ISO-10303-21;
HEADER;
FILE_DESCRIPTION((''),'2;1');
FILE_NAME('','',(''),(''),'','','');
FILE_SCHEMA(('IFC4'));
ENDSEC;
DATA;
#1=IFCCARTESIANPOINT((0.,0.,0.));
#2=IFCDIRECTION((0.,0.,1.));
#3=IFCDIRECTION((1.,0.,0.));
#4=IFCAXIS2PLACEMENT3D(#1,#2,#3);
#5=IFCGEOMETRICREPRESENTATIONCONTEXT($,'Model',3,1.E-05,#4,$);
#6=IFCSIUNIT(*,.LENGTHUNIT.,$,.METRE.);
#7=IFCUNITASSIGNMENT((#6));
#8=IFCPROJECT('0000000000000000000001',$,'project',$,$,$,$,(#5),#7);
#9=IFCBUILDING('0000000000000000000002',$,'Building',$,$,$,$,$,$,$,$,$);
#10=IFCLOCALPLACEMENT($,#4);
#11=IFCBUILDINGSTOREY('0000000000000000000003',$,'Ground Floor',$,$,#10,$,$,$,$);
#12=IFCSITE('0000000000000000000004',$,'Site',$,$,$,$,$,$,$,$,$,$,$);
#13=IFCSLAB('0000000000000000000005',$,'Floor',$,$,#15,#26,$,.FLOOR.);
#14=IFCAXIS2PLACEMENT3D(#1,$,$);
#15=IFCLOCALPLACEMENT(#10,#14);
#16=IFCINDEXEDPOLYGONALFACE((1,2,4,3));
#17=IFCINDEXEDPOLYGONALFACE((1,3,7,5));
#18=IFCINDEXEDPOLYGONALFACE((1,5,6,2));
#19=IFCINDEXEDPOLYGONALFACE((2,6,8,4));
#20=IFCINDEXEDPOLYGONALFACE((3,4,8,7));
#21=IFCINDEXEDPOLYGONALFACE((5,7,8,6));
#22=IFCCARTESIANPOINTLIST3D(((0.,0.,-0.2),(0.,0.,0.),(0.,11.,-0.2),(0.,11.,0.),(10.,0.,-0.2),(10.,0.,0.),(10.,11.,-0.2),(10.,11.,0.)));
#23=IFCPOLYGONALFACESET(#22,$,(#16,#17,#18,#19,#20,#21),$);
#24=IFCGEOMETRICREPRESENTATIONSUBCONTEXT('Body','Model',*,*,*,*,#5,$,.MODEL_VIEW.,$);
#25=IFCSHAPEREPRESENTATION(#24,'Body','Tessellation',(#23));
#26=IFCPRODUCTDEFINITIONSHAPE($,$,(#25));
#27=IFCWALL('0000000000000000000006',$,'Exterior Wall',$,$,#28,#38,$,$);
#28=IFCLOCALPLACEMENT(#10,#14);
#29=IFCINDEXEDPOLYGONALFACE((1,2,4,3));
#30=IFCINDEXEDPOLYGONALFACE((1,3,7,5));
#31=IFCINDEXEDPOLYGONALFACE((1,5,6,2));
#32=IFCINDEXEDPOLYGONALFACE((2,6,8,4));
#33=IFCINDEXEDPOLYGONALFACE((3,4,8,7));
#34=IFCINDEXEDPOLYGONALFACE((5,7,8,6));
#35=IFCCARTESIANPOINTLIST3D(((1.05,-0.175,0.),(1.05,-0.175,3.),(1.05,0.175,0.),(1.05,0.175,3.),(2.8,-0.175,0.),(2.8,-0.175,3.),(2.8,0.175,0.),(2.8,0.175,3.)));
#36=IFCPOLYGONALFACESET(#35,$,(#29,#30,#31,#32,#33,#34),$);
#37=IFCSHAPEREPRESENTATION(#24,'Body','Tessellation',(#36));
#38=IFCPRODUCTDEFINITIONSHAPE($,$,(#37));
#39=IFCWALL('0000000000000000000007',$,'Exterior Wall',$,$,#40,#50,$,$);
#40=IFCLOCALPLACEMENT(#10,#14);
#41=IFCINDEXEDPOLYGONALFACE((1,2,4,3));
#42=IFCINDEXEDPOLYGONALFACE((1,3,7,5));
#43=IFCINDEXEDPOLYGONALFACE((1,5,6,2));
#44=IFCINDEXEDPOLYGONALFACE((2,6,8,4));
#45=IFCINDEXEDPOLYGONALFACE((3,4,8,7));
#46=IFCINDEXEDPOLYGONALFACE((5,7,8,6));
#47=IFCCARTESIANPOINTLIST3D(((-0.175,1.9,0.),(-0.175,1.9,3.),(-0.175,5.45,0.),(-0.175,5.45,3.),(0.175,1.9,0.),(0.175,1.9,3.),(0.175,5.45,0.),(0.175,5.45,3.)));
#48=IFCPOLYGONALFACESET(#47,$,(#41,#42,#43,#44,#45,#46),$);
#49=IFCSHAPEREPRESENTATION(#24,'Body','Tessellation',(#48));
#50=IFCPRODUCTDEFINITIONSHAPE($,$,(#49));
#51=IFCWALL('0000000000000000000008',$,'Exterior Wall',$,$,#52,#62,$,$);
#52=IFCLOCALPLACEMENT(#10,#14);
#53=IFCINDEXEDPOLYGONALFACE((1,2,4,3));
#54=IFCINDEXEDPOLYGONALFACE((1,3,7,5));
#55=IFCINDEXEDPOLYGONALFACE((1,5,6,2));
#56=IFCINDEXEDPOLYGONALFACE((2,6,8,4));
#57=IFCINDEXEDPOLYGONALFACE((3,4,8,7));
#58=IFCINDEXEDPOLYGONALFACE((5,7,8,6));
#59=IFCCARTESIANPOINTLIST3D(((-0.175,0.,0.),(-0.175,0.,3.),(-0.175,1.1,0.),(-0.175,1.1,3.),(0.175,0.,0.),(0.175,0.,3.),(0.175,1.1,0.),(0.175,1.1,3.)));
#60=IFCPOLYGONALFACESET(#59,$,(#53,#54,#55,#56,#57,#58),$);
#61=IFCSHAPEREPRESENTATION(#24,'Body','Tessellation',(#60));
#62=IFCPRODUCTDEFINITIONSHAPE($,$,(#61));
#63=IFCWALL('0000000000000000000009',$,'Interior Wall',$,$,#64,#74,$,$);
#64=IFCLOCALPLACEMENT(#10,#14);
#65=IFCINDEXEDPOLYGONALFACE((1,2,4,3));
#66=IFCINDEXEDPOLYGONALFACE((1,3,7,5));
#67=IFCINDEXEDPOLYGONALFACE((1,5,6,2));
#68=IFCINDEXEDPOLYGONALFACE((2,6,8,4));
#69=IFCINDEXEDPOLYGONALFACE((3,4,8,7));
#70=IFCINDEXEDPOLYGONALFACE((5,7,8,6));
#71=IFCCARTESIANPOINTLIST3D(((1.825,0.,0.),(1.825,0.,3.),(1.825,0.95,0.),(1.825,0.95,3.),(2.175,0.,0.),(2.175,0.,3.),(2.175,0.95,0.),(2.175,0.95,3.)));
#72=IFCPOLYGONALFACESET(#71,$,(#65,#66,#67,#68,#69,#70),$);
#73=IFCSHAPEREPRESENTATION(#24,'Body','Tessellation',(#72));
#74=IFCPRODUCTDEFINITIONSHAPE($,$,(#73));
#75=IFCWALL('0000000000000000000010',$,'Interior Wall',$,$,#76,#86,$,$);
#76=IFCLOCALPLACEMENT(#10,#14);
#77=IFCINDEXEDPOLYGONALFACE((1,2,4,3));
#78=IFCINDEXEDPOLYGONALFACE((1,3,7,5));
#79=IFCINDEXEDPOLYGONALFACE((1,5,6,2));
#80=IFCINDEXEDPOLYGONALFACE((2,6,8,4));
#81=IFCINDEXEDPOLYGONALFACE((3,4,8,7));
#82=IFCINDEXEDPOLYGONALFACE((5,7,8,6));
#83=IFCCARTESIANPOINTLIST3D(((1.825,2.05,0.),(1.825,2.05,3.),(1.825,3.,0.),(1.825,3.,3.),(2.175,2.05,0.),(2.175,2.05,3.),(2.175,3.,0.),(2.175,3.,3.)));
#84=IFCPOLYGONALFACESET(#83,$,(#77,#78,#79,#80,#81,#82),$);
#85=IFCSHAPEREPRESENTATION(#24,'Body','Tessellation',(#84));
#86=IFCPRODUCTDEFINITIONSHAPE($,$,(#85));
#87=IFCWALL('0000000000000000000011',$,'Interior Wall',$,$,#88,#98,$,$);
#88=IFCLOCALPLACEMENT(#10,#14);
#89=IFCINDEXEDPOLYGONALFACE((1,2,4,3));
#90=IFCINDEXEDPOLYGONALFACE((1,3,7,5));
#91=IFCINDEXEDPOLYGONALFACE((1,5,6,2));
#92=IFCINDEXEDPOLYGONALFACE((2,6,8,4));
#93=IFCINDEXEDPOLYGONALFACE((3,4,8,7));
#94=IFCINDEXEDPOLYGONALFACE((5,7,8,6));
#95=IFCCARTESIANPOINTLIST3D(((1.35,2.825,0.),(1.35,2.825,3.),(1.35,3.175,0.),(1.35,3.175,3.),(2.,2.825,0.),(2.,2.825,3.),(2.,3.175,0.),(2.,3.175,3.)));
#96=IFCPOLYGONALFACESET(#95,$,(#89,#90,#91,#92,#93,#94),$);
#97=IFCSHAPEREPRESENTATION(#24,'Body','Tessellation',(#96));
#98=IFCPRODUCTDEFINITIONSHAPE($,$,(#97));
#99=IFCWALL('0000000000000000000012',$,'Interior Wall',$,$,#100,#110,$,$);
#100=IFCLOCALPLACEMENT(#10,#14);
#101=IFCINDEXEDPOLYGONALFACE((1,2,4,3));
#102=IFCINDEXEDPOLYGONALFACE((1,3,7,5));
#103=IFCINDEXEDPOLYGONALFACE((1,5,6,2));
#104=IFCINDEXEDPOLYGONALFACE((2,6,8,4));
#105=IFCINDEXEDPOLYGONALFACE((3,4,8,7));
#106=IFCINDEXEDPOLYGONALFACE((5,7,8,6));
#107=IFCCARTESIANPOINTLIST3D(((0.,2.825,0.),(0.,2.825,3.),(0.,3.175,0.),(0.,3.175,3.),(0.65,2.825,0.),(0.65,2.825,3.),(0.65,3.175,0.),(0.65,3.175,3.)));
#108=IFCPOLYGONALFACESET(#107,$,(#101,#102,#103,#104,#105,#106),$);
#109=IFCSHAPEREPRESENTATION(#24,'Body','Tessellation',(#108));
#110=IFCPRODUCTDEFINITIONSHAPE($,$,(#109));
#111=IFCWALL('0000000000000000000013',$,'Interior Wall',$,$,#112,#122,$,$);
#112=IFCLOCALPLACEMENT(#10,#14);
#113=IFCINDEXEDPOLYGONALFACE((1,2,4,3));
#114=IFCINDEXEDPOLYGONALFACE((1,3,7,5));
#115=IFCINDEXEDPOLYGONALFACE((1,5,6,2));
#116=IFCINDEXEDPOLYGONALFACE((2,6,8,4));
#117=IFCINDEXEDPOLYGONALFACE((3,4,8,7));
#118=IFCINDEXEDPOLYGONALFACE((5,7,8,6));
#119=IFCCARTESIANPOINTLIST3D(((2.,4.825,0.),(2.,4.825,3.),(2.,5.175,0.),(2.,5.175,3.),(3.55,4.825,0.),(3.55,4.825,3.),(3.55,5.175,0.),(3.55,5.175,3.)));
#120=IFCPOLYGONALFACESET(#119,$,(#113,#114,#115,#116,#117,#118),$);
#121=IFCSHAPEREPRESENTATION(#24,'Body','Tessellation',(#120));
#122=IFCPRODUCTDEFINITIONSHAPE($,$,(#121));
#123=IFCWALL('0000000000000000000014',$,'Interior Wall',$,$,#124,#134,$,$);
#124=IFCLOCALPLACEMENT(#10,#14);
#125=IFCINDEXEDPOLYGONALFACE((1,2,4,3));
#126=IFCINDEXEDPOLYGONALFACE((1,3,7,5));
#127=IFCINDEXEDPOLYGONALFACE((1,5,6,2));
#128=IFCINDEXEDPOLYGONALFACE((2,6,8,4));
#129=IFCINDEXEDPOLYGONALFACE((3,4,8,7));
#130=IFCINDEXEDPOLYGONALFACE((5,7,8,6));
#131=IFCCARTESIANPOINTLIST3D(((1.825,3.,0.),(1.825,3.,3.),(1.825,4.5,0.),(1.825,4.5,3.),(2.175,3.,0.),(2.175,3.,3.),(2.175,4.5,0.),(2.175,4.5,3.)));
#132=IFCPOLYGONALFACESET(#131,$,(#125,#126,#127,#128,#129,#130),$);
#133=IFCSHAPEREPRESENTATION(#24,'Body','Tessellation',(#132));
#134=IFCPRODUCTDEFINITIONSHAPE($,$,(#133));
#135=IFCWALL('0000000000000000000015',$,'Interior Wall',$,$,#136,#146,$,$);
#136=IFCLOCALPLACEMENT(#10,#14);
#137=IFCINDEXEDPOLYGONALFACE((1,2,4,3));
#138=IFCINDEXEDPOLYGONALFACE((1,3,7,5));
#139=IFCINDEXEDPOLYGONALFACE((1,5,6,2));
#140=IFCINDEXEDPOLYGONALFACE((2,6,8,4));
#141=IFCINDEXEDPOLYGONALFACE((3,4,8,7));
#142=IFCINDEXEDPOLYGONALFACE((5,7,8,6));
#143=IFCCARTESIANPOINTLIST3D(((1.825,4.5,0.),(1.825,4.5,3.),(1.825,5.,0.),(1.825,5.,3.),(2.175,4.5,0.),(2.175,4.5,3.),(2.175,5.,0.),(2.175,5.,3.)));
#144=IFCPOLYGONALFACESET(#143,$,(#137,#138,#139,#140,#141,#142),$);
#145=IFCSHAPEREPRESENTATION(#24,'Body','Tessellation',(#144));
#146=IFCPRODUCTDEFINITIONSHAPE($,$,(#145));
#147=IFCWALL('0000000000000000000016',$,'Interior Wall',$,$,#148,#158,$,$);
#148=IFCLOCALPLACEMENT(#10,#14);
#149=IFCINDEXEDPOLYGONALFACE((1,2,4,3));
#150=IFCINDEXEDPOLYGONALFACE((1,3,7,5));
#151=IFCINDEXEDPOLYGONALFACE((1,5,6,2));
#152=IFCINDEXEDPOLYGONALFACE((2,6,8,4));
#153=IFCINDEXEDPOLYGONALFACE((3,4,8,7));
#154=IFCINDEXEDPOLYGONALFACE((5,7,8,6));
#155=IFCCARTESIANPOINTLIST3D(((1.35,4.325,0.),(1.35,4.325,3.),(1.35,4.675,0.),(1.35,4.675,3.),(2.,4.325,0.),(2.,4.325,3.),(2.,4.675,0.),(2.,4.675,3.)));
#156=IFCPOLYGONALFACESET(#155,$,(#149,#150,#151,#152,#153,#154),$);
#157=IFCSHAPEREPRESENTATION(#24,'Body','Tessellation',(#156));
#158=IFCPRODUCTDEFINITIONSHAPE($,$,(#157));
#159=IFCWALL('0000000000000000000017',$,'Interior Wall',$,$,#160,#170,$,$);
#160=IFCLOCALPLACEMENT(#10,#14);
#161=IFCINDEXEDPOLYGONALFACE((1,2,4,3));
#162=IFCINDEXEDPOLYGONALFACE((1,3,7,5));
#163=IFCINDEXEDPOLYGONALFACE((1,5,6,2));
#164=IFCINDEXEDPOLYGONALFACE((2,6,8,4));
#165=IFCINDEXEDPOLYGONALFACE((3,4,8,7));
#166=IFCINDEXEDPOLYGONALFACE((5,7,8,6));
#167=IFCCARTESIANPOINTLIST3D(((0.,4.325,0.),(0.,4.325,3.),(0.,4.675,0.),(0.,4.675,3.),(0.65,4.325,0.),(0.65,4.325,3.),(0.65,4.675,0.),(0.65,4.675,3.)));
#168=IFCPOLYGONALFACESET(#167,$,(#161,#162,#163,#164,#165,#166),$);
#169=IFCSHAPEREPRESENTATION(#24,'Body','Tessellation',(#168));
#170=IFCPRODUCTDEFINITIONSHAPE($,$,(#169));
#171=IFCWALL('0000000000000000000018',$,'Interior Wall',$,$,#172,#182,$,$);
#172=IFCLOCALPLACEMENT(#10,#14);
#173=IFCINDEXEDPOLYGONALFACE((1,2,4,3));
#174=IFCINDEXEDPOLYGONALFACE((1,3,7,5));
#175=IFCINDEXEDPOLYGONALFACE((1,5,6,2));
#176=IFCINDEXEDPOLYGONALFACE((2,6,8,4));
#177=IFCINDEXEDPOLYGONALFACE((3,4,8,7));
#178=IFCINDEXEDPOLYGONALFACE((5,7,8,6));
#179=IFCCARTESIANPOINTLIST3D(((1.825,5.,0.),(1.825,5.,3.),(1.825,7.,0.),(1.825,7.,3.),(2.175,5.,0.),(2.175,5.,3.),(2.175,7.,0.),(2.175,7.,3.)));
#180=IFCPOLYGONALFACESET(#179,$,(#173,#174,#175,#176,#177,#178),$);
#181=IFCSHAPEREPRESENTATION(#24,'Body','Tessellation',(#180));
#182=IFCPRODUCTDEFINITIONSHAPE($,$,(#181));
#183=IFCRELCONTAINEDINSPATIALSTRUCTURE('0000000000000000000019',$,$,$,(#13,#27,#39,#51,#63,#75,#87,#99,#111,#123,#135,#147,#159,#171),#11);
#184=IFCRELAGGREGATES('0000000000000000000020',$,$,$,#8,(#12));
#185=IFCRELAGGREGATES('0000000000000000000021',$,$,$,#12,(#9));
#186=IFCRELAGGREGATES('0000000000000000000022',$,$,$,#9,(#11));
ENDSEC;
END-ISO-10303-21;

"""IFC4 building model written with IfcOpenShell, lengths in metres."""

from ifc_helpers import new_model, si_unit, frame, origin_with_axes, place, context, subcontext, project, spatial, indexed_curve, outline, extrude, element, save


model = new_model("IFC4")

# Units and contexts
model_context = context("Model", 3, precision=1e-05, world=origin_with_axes())
body_context = subcontext(model_context, "Body", "Model", "MODEL_VIEW")
ifc_project = project(units=[si_unit("LENGTHUNIT", "METRE")], contexts=[model_context])

# Site, building, storey
site = spatial("IfcSite", under=ifc_project, Name="Site")
building = spatial("IfcBuilding", under=site, Name="Building")
storey_placement = place(None, origin_with_axes())
storey = spatial("IfcBuildingStorey", under=building, at=storey_placement, Name="Ground Floor")

# Slab
slab_placement = place(storey_placement, frame((0.0, 0.0, -0.2), z_axis=(0.0, 0.0, 1.0), x_axis=(1.0, 0.0, 0.0)))
element("IfcSlab", 1, at=slab_placement, inside=storey, Name="Floor", PredefinedType="FLOOR", context=body_context, shape_type="SweptSolid", body=[
    extrude(outline(indexed_curve([(0.0, 0.0), (10.0, 0.0), (10.0, 11.0), (0.0, 11.0)])), None, (0.0, 0.0, 1.0), 0.2),
])

# Walls
wall_1_placement = place(storey_placement, frame((1.05, 0.0, 0.0), z_axis=(0.0, 0.0, 1.0), x_axis=(1.0, 0.0, 0.0)))
element("IfcWall", 2, at=wall_1_placement, inside=storey, Name="Exterior Wall", context=body_context, shape_type="SweptSolid", body=[
    extrude(outline(indexed_curve([(0.0, 0.0), (0.0, 0.35), (1.75, 0.35), (1.75, 0.0), (0.0, 0.0)], self_intersect=False)), frame((0.0, -0.175, 0.0), z_axis=(0.0, 0.0, 1.0), x_axis=(1.0, 0.0, 0.0)), (0.0, 0.0, 1.0), 3.0),
])
wall_2_placement = place(storey_placement, frame((0.0, 5.45, 0.0), z_axis=(0.0, 0.0, 1.0), x_axis=(0.0, -1.0, 0.0)))
element("IfcWall", 3, at=wall_2_placement, inside=storey, Name="Exterior Wall", context=body_context, shape_type="SweptSolid", body=[
    extrude(outline(indexed_curve([(0.0, 0.0), (0.0, 0.35), (3.55, 0.35), (3.55, 0.0), (0.0, 0.0)], self_intersect=False)), frame((0.0, -0.175, 0.0), z_axis=(0.0, 0.0, 1.0), x_axis=(1.0, 0.0, 0.0)), (0.0, 0.0, 1.0), 3.0),
])
wall_3_placement = place(storey_placement, frame((0.0, 1.1, 0.0), z_axis=(0.0, 0.0, 1.0), x_axis=(0.0, -1.0, 0.0)))
element("IfcWall", 4, at=wall_3_placement, inside=storey, Name="Exterior Wall", context=body_context, shape_type="SweptSolid", body=[
    extrude(outline(indexed_curve([(0.0, 0.0), (0.0, 0.35), (1.1, 0.35), (1.1, 0.0), (0.0, 0.0)], self_intersect=False)), frame((0.0, -0.175, 0.0), z_axis=(0.0, 0.0, 1.0), x_axis=(1.0, 0.0, 0.0)), (0.0, 0.0, 1.0), 3.0),
])
wall_4_placement = place(storey_placement, frame((2.0, 0.0, 0.0), z_axis=(0.0, 0.0, 1.0), x_axis=(0.0, 1.0, 0.0)))
element("IfcWall", 5, at=wall_4_placement, inside=storey, Name="Interior Wall", context=body_context, shape_type="SweptSolid", body=[
    extrude(outline(indexed_curve([(0.0, 0.0), (0.0, 0.35), (0.95, 0.35), (0.95, 0.0), (0.0, 0.0)], self_intersect=False)), frame((0.0, -0.175, 0.0), z_axis=(0.0, 0.0, 1.0), x_axis=(1.0, 0.0, 0.0)), (0.0, 0.0, 1.0), 3.0),
])
wall_5_placement = place(storey_placement, frame((2.0, 2.05, 0.0), z_axis=(0.0, 0.0, 1.0), x_axis=(0.0, 1.0, 0.0)))
element("IfcWall", 6, at=wall_5_placement, inside=storey, Name="Interior Wall", context=body_context, shape_type="SweptSolid", body=[
    extrude(outline(indexed_curve([(0.0, 0.0), (0.0, 0.35), (0.95, 0.35), (0.95, 0.0), (0.0, 0.0)], self_intersect=False)), frame((0.0, -0.175, 0.0), z_axis=(0.0, 0.0, 1.0), x_axis=(1.0, 0.0, 0.0)), (0.0, 0.0, 1.0), 3.0),
])
for number, where, z_axis, x_axis, name in (
    (7, (2.0, 3.0, 0.0), (0.0, 0.0, 1.0), (-1.0, 0.0, 0.0), "Interior Wall"),
    (8, (0.65, 3.0, 0.0), (0.0, 0.0, 1.0), (-1.0, 0.0, 0.0), "Interior Wall"),
):
    element("IfcWall", number, at=place(storey_placement, frame(where, z_axis=z_axis, x_axis=x_axis)), inside=storey, Name=name, context=body_context, shape_type="SweptSolid", body=[
        extrude(outline(indexed_curve([(0.0, 0.0), (0.0, 0.35), (0.65, 0.35), (0.65, 0.0), (0.0, 0.0)], self_intersect=False)), frame((0.0, -0.175, 0.0), z_axis=(0.0, 0.0, 1.0), x_axis=(1.0, 0.0, 0.0)), (0.0, 0.0, 1.0), 3.0),
    ])
wall_6_placement = place(storey_placement, frame((3.55, 5.0, 0.0), z_axis=(0.0, 0.0, 1.0), x_axis=(-1.0, 0.0, 0.0)))
element("IfcWall", 9, at=wall_6_placement, inside=storey, Name="Interior Wall", context=body_context, shape_type="SweptSolid", body=[
    extrude(outline(indexed_curve([(0.0, 0.0), (0.0, 0.35), (1.55, 0.35), (1.55, 0.0), (0.0, 0.0)], self_intersect=False)), frame((0.0, -0.175, 0.0), z_axis=(0.0, 0.0, 1.0), x_axis=(1.0, 0.0, 0.0)), (0.0, 0.0, 1.0), 3.0),
])
wall_7_placement = place(storey_placement, frame((2.0, 4.5, 0.0), z_axis=(0.0, 0.0, 1.0), x_axis=(0.0, -1.0, 0.0)))
element("IfcWall", 10, at=wall_7_placement, inside=storey, Name="Interior Wall", context=body_context, shape_type="SweptSolid", body=[
    extrude(outline(indexed_curve([(0.0, 0.0), (0.0, 0.35), (1.5, 0.35), (1.5, 0.0), (0.0, 0.0)], self_intersect=False)), frame((0.0, -0.175, 0.0), z_axis=(0.0, 0.0, 1.0), x_axis=(1.0, 0.0, 0.0)), (0.0, 0.0, 1.0), 3.0),
])
wall_8_placement = place(storey_placement, frame((2.0, 5.0, 0.0), z_axis=(0.0, 0.0, 1.0), x_axis=(0.0, -1.0, 0.0)))
element("IfcWall", 11, at=wall_8_placement, inside=storey, Name="Interior Wall", context=body_context, shape_type="SweptSolid", body=[
    extrude(outline(indexed_curve([(0.0, 0.0), (0.0, 0.35), (0.5, 0.35), (0.5, 0.0), (0.0, 0.0)], self_intersect=False)), frame((0.0, -0.175, 0.0), z_axis=(0.0, 0.0, 1.0), x_axis=(1.0, 0.0, 0.0)), (0.0, 0.0, 1.0), 3.0),
])
for number, where, z_axis, x_axis, name in (
    (12, (2.0, 4.5, 0.0), (0.0, 0.0, 1.0), (-1.0, 0.0, 0.0), "Interior Wall"),
    (13, (0.65, 4.5, 0.0), (0.0, 0.0, 1.0), (-1.0, 0.0, 0.0), "Interior Wall"),
):
    element("IfcWall", number, at=place(storey_placement, frame(where, z_axis=z_axis, x_axis=x_axis)), inside=storey, Name=name, context=body_context, shape_type="SweptSolid", body=[
        extrude(outline(indexed_curve([(0.0, 0.0), (0.0, 0.35), (0.65, 0.35), (0.65, 0.0), (0.0, 0.0)], self_intersect=False)), frame((0.0, -0.175, 0.0), z_axis=(0.0, 0.0, 1.0), x_axis=(1.0, 0.0, 0.0)), (0.0, 0.0, 1.0), 3.0),
    ])
wall_9_placement = place(storey_placement, frame((2.0, 5.0, 0.0), z_axis=(0.0, 0.0, 1.0), x_axis=(0.0, 1.0, 0.0)))
element("IfcWall", 14, at=wall_9_placement, inside=storey, Name="Interior Wall", context=body_context, shape_type="SweptSolid", body=[
    extrude(outline(indexed_curve([(0.0, 0.0), (0.0, 0.35), (2.0, 0.35), (2.0, 0.0), (0.0, 0.0)], self_intersect=False)), frame((0.0, -0.175, 0.0), z_axis=(0.0, 0.0, 1.0), x_axis=(1.0, 0.0, 0.0)), (0.0, 0.0, 1.0), 3.0),
])

save(model, "model.ifc")
